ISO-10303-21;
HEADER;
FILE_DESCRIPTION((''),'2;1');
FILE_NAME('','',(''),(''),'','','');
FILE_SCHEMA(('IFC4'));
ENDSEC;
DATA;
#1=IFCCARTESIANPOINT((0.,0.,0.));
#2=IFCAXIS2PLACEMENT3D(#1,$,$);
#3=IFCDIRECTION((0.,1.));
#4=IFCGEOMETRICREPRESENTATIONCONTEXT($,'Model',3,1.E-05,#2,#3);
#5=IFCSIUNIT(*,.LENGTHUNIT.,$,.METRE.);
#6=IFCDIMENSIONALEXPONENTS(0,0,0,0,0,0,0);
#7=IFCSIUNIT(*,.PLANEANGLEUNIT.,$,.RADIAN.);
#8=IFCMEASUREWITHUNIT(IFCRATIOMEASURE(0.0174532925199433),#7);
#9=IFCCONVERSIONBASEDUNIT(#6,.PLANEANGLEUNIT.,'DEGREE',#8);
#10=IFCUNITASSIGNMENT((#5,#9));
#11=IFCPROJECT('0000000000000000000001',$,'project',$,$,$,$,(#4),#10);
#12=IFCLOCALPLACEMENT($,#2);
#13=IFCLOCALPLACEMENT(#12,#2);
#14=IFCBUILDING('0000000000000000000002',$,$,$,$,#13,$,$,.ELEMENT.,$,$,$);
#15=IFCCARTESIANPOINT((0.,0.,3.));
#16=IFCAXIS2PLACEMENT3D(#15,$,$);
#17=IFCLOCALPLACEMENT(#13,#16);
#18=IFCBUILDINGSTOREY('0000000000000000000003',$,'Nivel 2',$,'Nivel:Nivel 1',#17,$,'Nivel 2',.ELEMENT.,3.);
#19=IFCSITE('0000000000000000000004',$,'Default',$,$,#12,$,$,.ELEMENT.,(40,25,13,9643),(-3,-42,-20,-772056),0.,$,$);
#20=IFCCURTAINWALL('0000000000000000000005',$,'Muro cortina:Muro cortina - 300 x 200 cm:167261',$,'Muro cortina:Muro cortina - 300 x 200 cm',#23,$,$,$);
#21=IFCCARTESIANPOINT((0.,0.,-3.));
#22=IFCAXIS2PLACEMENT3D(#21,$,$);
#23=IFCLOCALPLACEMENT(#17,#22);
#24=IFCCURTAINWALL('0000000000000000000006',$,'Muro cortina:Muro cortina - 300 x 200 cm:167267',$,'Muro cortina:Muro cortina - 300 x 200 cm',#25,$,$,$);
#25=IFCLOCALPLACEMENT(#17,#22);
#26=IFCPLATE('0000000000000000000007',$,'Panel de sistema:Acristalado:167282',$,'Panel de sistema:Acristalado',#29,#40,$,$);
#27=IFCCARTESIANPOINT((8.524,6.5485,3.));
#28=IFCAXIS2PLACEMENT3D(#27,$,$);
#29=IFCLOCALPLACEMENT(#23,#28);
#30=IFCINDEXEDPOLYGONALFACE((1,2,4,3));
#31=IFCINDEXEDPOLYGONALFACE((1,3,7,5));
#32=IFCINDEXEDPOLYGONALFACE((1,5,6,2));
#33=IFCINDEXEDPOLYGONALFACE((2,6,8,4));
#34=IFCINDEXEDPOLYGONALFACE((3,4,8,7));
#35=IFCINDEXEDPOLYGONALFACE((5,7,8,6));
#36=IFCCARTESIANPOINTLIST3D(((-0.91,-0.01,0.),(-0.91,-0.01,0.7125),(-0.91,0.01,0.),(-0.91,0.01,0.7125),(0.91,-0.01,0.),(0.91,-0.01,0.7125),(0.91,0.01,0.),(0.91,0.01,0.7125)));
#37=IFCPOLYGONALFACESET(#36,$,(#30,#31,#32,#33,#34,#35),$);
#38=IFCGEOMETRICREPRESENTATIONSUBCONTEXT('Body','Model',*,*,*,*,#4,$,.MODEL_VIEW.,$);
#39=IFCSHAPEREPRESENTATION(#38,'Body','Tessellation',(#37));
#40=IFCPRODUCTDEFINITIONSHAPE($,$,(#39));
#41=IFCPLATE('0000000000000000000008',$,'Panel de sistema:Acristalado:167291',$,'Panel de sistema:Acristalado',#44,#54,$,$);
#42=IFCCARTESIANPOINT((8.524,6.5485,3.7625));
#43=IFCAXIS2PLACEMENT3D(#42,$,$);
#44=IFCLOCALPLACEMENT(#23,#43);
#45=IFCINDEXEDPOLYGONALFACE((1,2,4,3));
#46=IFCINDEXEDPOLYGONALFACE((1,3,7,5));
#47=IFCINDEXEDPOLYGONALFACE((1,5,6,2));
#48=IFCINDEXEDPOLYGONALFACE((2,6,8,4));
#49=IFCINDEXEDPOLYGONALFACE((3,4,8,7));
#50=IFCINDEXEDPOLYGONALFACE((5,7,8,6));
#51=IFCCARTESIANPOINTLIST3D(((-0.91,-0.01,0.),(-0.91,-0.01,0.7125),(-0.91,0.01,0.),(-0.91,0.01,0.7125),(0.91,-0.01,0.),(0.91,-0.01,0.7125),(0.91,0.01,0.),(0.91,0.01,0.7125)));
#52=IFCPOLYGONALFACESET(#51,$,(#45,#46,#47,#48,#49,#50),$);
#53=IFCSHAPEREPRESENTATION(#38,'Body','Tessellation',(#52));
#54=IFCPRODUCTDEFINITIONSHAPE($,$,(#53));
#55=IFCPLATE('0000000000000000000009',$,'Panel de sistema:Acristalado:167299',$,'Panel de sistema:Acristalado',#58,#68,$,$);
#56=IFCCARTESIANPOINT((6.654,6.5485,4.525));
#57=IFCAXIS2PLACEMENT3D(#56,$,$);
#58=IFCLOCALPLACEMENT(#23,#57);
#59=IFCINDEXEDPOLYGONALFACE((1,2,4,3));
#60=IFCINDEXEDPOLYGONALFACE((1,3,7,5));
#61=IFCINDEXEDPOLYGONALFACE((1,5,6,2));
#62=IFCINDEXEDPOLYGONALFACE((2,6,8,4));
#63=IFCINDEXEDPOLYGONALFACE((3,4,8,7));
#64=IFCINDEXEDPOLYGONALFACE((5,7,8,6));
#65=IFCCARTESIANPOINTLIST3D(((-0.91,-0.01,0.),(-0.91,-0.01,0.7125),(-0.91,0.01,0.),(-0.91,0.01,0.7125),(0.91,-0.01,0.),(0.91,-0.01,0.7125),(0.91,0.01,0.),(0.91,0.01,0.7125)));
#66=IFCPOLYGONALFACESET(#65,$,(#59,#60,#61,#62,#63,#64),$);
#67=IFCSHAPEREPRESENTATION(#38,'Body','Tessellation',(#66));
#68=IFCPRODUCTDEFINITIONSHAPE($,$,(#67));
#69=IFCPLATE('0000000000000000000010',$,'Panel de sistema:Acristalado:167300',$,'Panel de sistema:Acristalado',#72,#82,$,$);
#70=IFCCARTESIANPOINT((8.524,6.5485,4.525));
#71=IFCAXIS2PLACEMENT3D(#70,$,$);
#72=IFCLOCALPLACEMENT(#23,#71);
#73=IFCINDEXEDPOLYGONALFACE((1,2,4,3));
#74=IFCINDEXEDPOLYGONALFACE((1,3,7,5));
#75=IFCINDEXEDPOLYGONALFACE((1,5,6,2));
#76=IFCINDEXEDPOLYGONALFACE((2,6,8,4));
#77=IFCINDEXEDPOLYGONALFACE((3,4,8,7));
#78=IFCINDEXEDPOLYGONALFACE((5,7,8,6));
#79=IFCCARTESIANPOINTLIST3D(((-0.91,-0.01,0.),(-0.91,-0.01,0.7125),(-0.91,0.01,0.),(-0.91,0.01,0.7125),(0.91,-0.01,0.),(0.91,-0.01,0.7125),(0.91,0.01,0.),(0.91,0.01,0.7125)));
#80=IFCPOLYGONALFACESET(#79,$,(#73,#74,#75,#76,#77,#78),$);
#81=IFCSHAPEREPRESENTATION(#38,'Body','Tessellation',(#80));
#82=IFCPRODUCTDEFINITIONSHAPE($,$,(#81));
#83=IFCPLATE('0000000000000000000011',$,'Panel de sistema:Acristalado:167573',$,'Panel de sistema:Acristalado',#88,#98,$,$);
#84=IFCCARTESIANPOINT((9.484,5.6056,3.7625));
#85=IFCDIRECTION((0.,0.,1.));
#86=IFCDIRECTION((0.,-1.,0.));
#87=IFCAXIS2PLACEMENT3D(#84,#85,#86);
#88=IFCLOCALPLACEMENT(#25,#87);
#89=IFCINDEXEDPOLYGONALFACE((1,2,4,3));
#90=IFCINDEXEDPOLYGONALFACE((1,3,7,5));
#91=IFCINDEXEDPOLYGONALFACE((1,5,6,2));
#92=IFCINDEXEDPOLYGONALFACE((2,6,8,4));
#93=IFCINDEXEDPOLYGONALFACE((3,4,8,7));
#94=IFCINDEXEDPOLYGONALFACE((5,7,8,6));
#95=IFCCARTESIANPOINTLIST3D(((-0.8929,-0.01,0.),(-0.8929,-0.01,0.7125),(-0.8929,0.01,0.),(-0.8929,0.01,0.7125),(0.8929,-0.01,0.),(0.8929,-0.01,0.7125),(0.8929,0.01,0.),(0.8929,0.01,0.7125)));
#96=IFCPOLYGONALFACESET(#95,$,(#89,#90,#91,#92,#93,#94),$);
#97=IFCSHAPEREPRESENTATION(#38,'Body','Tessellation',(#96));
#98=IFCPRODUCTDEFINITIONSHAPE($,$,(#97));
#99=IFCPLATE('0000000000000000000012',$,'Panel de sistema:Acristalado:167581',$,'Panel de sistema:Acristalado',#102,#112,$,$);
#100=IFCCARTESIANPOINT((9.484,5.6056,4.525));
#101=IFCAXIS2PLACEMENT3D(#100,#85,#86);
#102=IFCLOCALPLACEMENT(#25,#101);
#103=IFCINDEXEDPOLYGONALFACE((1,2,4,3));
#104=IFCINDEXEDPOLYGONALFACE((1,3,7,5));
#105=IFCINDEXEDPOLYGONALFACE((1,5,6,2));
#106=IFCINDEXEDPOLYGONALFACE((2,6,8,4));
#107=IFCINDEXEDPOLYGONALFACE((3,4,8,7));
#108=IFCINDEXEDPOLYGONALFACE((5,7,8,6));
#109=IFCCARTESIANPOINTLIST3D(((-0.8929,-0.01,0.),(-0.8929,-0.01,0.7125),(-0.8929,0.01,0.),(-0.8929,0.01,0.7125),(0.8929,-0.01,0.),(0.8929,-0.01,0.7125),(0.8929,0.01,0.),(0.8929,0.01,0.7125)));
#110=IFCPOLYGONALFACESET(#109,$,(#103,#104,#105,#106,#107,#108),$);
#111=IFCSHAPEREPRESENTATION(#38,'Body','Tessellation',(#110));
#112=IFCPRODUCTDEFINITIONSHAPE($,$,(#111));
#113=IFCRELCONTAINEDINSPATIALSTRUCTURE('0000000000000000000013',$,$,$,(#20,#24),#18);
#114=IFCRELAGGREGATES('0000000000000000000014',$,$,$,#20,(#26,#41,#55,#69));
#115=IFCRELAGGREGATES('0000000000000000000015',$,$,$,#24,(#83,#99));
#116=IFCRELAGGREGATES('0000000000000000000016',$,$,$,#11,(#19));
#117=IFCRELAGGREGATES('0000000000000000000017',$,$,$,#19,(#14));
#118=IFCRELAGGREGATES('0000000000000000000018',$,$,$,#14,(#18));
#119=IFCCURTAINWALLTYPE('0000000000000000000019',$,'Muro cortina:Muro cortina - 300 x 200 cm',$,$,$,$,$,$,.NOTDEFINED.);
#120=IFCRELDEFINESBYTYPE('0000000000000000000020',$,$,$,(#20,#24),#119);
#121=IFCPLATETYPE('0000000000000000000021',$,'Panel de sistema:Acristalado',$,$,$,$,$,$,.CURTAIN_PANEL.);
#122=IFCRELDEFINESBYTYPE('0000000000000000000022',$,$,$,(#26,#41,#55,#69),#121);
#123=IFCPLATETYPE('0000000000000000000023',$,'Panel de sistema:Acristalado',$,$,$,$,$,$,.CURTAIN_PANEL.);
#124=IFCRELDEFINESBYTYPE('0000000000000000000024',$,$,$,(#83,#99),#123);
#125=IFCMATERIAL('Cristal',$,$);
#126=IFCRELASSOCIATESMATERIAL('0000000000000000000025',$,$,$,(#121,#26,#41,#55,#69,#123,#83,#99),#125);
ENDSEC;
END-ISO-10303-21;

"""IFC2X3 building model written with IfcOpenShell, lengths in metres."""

from ifc_helpers import new_model, entity, si_unit, converted_unit, direction, frame, origin, origin_2d_with_axis, place, context, subcontext, project, spatial, rectangle, extrude, source, transform, mapped, material, type_object, type_shapes, element, aggregate, save


model = new_model("IFC2X3")

# Units and contexts
model_context = context("Model", 3, precision=1e-05, world=origin(), true_north=direction((0.0, 1.0)))
body_context = subcontext(model_context, "Body", "Model", "MODEL_VIEW")
ifc_project = project(units=[si_unit("LENGTHUNIT", "METRE"), converted_unit("PLANEANGLEUNIT", "DEGREE", entity("IfcRatioMeasure", 0.0174532925199433), si_unit("PLANEANGLEUNIT", "RADIAN"), dimensions=[0, 0, 0, 0, 0, 0, 0])], contexts=[model_context])

# Site, building, storey
site_placement = place(None, origin())
site = spatial("IfcSite", under=ifc_project, at=site_placement, Name="Default", CompositionType="ELEMENT", RefLatitude=(40, 25, 13, 9643), RefLongitude=(-3, -42, -20, -772056), RefElevation=0.0)
building_placement = place(site_placement, origin())
building = spatial("IfcBuilding", under=site, at=building_placement, CompositionType="ELEMENT")
storey_placement = place(building_placement, frame((0.0, 0.0, 3.0)))
storey = spatial("IfcBuildingStorey", under=building, at=storey_placement, Name="Nivel 2", ObjectType="Nivel:Nivel 1", LongName="Nivel 2", CompositionType="ELEMENT", Elevation=3.0)

# Curtain walls
curtain_wall_type = type_object("IfcCurtainWallType", Name="Muro cortina:Muro cortina - 300 x 200 cm", PredefinedType="NOTDEFINED")
curtain_wall_1_placement = place(storey_placement, frame((0.0, 0.0, -3.0)))
curtain_wall_1 = element("IfcCurtainWall", 1, at=curtain_wall_1_placement, inside=storey, type_object=curtain_wall_type, Name="Muro cortina:Muro cortina - 300 x 200 cm:167261", ObjectType="Muro cortina:Muro cortina - 300 x 200 cm")
curtain_wall_2_placement = place(storey_placement, frame((0.0, 0.0, -3.0)))
curtain_wall_2 = element("IfcCurtainWall", 2, at=curtain_wall_2_placement, inside=storey, type_object=curtain_wall_type, Name="Muro cortina:Muro cortina - 300 x 200 cm:167267", ObjectType="Muro cortina:Muro cortina - 300 x 200 cm")

# Plates
ifc_material_1 = material(Name="Cristal")
plate_type_1 = type_object("IfcPlateType", Name="Panel de sistema:Acristalado", PredefinedType="CURTAIN_PANEL", material=ifc_material_1)
shared_shape_1 = source(origin(), body_context, "Body", "SweptSolid", [
    extrude(rectangle(XDim=0.02, YDim=1.82, at=origin_2d_with_axis()), frame((0.0, 0.0, 0.0), z_axis=(0.0, 0.0, 1.0), x_axis=(0.0, 1.0, 0.0)), (0.0, 0.0, 1.0), 0.7125),
])
type_shapes(plate_type_1, [shared_shape_1])
plate_1_placement = place(curtain_wall_1_placement, frame((8.524, 6.5485, 3.0)))
plate_1 = element("IfcPlate", 3, at=plate_1_placement, type_object=plate_type_1, material=ifc_material_1, Name="Panel de sistema:Acristalado:167282", ObjectType="Panel de sistema:Acristalado", context=body_context, shape_type="MappedRepresentation", body=[
    mapped(shared_shape_1, transform((0.0, 0.0, 0.0), scale=1.0)),
])
plate_2_placement = place(curtain_wall_1_placement, frame((8.524, 6.5485, 3.7625)))
plate_2 = element("IfcPlate", 4, at=plate_2_placement, type_object=plate_type_1, material=ifc_material_1, Name="Panel de sistema:Acristalado:167291", ObjectType="Panel de sistema:Acristalado", context=body_context, shape_type="MappedRepresentation", body=[
    mapped(shared_shape_1, transform((0.0, 0.0, 0.0), scale=1.0)),
])
plate_3_placement = place(curtain_wall_1_placement, frame((6.654, 6.5485, 4.525)))
plate_3 = element("IfcPlate", 5, at=plate_3_placement, type_object=plate_type_1, material=ifc_material_1, Name="Panel de sistema:Acristalado:167299", ObjectType="Panel de sistema:Acristalado", context=body_context, shape_type="MappedRepresentation", body=[
    mapped(shared_shape_1, transform((0.0, 0.0, 0.0), scale=1.0)),
])
plate_4_placement = place(curtain_wall_1_placement, frame((8.524, 6.5485, 4.525)))
plate_4 = element("IfcPlate", 6, at=plate_4_placement, type_object=plate_type_1, material=ifc_material_1, Name="Panel de sistema:Acristalado:167300", ObjectType="Panel de sistema:Acristalado", context=body_context, shape_type="MappedRepresentation", body=[
    mapped(shared_shape_1, transform((0.0, 0.0, 0.0), scale=1.0)),
])
aggregate(curtain_wall_1, [plate_1, plate_2, plate_3, plate_4])
plate_type_2 = type_object("IfcPlateType", Name="Panel de sistema:Acristalado", PredefinedType="CURTAIN_PANEL", material=ifc_material_1)
shared_shape_2 = source(origin(), body_context, "Body", "SweptSolid", [
    extrude(rectangle(XDim=0.02, YDim=1.7857, at=origin_2d_with_axis()), frame((0.0, 0.0, 0.0), z_axis=(0.0, 0.0, 1.0), x_axis=(0.0, 1.0, 0.0)), (0.0, 0.0, 1.0), 0.7125),
])
type_shapes(plate_type_2, [shared_shape_2])
plate_5_placement = place(curtain_wall_2_placement, frame((9.484, 5.6056, 3.7625), z_axis=(0.0, 0.0, 1.0), x_axis=(0.0, -1.0, 0.0)))
plate_5 = element("IfcPlate", 7, at=plate_5_placement, type_object=plate_type_2, material=ifc_material_1, Name="Panel de sistema:Acristalado:167573", ObjectType="Panel de sistema:Acristalado", context=body_context, shape_type="MappedRepresentation", body=[
    mapped(shared_shape_2, transform((0.0, 0.0, 0.0), scale=1.0)),
])
plate_6_placement = place(curtain_wall_2_placement, frame((9.484, 5.6056, 4.525), z_axis=(0.0, 0.0, 1.0), x_axis=(0.0, -1.0, 0.0)))
plate_6 = element("IfcPlate", 8, at=plate_6_placement, type_object=plate_type_2, material=ifc_material_1, Name="Panel de sistema:Acristalado:167581", ObjectType="Panel de sistema:Acristalado", context=body_context, shape_type="MappedRepresentation", body=[
    mapped(shared_shape_2, transform((0.0, 0.0, 0.0), scale=1.0)),
])
aggregate(curtain_wall_2, [plate_5, plate_6])

save(model, "model.ifc")
